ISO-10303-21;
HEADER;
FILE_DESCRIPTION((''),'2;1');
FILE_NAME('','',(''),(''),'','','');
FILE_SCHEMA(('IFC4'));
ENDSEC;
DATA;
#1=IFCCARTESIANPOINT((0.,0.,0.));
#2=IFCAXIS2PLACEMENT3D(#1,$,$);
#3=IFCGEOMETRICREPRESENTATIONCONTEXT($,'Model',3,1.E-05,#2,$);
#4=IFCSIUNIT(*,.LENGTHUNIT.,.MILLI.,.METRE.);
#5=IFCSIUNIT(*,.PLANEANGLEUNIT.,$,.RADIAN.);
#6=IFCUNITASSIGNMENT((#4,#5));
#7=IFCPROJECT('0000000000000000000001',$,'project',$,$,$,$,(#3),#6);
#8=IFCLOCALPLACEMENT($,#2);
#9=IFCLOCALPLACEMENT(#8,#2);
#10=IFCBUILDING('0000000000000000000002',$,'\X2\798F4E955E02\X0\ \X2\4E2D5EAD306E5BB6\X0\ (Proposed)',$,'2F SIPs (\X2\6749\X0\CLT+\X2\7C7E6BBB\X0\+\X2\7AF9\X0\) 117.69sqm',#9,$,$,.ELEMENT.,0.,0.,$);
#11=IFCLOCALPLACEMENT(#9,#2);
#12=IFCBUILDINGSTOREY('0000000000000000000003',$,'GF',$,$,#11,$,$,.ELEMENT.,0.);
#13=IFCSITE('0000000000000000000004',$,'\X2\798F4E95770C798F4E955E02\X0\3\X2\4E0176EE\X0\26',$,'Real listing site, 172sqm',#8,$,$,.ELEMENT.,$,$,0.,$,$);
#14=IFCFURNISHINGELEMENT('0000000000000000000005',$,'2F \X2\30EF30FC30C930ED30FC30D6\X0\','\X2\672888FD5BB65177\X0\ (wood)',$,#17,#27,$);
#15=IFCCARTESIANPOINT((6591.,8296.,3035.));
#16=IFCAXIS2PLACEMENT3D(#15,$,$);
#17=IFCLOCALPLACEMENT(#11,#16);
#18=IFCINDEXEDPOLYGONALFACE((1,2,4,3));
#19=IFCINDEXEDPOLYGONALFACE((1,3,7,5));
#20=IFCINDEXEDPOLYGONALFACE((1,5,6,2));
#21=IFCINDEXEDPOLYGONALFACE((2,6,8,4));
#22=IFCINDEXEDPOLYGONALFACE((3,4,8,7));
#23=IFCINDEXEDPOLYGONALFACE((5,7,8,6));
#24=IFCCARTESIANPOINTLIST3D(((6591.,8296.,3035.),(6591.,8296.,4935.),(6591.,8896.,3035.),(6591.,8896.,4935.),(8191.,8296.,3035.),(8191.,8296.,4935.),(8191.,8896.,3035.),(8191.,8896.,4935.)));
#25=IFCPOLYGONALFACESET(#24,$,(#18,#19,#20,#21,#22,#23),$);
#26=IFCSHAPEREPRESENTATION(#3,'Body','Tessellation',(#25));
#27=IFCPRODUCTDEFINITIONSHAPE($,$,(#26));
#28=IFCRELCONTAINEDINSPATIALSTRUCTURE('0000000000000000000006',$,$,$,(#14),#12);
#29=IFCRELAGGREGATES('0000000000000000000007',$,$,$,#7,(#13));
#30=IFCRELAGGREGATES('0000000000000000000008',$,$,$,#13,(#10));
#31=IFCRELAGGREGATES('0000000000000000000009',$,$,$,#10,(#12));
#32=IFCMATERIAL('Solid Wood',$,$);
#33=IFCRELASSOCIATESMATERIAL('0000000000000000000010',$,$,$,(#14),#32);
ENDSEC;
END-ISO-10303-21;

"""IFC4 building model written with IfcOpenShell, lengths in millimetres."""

from ifc_helpers import new_model, si_unit, frame, frame_2d, origin, place, context, project, spatial, rectangle, extrude, material, element, save


model = new_model("IFC4")

# Units and contexts
model_context = context("Model", 3, precision=1e-05, world=origin())
ifc_project = project(units=[si_unit("LENGTHUNIT", "METRE", prefix="MILLI"), si_unit("PLANEANGLEUNIT", "RADIAN")], contexts=[model_context])

# Site, building, storey
site_placement = place(None, origin())
site = spatial("IfcSite", under=ifc_project, at=site_placement, Name="福井県福井市3丁目26", ObjectType="Real listing site, 172sqm", CompositionType="ELEMENT", RefElevation=0.0)
building_placement = place(site_placement, origin())
building = spatial("IfcBuilding", under=site, at=building_placement, Name="福井市 中庭の家 (Proposed)", ObjectType="2F SIPs (杉CLT+籾殻+竹) 117.69sqm", CompositionType="ELEMENT", ElevationOfRefHeight=0.0, ElevationOfTerrain=0.0)
storey_placement = place(building_placement, origin())
storey = spatial("IfcBuildingStorey", under=building, at=storey_placement, Name="GF", CompositionType="ELEMENT", Elevation=0.0)

# Shared definitions
ifc_material_1 = material(Name="Solid Wood")

# Furnishing element
furnishing_1_placement = place(storey_placement, frame((6591.0, 8296.0, 3035.0)))
element("IfcFurnishingElement", 1, at=furnishing_1_placement, inside=storey, material=ifc_material_1, Name="2F ワードローブ", Description="木製家具 (wood)", context=model_context, shape_type="SweptSolid", body=[
    extrude(rectangle(XDim=1600.0, YDim=600.0, at=frame_2d((800.0, 300.0))), frame((6591.0, 8296.0, 3035.0)), (0.0, 0.0, 1.0), 1900.0),
])

save(model, "model.ifc")
